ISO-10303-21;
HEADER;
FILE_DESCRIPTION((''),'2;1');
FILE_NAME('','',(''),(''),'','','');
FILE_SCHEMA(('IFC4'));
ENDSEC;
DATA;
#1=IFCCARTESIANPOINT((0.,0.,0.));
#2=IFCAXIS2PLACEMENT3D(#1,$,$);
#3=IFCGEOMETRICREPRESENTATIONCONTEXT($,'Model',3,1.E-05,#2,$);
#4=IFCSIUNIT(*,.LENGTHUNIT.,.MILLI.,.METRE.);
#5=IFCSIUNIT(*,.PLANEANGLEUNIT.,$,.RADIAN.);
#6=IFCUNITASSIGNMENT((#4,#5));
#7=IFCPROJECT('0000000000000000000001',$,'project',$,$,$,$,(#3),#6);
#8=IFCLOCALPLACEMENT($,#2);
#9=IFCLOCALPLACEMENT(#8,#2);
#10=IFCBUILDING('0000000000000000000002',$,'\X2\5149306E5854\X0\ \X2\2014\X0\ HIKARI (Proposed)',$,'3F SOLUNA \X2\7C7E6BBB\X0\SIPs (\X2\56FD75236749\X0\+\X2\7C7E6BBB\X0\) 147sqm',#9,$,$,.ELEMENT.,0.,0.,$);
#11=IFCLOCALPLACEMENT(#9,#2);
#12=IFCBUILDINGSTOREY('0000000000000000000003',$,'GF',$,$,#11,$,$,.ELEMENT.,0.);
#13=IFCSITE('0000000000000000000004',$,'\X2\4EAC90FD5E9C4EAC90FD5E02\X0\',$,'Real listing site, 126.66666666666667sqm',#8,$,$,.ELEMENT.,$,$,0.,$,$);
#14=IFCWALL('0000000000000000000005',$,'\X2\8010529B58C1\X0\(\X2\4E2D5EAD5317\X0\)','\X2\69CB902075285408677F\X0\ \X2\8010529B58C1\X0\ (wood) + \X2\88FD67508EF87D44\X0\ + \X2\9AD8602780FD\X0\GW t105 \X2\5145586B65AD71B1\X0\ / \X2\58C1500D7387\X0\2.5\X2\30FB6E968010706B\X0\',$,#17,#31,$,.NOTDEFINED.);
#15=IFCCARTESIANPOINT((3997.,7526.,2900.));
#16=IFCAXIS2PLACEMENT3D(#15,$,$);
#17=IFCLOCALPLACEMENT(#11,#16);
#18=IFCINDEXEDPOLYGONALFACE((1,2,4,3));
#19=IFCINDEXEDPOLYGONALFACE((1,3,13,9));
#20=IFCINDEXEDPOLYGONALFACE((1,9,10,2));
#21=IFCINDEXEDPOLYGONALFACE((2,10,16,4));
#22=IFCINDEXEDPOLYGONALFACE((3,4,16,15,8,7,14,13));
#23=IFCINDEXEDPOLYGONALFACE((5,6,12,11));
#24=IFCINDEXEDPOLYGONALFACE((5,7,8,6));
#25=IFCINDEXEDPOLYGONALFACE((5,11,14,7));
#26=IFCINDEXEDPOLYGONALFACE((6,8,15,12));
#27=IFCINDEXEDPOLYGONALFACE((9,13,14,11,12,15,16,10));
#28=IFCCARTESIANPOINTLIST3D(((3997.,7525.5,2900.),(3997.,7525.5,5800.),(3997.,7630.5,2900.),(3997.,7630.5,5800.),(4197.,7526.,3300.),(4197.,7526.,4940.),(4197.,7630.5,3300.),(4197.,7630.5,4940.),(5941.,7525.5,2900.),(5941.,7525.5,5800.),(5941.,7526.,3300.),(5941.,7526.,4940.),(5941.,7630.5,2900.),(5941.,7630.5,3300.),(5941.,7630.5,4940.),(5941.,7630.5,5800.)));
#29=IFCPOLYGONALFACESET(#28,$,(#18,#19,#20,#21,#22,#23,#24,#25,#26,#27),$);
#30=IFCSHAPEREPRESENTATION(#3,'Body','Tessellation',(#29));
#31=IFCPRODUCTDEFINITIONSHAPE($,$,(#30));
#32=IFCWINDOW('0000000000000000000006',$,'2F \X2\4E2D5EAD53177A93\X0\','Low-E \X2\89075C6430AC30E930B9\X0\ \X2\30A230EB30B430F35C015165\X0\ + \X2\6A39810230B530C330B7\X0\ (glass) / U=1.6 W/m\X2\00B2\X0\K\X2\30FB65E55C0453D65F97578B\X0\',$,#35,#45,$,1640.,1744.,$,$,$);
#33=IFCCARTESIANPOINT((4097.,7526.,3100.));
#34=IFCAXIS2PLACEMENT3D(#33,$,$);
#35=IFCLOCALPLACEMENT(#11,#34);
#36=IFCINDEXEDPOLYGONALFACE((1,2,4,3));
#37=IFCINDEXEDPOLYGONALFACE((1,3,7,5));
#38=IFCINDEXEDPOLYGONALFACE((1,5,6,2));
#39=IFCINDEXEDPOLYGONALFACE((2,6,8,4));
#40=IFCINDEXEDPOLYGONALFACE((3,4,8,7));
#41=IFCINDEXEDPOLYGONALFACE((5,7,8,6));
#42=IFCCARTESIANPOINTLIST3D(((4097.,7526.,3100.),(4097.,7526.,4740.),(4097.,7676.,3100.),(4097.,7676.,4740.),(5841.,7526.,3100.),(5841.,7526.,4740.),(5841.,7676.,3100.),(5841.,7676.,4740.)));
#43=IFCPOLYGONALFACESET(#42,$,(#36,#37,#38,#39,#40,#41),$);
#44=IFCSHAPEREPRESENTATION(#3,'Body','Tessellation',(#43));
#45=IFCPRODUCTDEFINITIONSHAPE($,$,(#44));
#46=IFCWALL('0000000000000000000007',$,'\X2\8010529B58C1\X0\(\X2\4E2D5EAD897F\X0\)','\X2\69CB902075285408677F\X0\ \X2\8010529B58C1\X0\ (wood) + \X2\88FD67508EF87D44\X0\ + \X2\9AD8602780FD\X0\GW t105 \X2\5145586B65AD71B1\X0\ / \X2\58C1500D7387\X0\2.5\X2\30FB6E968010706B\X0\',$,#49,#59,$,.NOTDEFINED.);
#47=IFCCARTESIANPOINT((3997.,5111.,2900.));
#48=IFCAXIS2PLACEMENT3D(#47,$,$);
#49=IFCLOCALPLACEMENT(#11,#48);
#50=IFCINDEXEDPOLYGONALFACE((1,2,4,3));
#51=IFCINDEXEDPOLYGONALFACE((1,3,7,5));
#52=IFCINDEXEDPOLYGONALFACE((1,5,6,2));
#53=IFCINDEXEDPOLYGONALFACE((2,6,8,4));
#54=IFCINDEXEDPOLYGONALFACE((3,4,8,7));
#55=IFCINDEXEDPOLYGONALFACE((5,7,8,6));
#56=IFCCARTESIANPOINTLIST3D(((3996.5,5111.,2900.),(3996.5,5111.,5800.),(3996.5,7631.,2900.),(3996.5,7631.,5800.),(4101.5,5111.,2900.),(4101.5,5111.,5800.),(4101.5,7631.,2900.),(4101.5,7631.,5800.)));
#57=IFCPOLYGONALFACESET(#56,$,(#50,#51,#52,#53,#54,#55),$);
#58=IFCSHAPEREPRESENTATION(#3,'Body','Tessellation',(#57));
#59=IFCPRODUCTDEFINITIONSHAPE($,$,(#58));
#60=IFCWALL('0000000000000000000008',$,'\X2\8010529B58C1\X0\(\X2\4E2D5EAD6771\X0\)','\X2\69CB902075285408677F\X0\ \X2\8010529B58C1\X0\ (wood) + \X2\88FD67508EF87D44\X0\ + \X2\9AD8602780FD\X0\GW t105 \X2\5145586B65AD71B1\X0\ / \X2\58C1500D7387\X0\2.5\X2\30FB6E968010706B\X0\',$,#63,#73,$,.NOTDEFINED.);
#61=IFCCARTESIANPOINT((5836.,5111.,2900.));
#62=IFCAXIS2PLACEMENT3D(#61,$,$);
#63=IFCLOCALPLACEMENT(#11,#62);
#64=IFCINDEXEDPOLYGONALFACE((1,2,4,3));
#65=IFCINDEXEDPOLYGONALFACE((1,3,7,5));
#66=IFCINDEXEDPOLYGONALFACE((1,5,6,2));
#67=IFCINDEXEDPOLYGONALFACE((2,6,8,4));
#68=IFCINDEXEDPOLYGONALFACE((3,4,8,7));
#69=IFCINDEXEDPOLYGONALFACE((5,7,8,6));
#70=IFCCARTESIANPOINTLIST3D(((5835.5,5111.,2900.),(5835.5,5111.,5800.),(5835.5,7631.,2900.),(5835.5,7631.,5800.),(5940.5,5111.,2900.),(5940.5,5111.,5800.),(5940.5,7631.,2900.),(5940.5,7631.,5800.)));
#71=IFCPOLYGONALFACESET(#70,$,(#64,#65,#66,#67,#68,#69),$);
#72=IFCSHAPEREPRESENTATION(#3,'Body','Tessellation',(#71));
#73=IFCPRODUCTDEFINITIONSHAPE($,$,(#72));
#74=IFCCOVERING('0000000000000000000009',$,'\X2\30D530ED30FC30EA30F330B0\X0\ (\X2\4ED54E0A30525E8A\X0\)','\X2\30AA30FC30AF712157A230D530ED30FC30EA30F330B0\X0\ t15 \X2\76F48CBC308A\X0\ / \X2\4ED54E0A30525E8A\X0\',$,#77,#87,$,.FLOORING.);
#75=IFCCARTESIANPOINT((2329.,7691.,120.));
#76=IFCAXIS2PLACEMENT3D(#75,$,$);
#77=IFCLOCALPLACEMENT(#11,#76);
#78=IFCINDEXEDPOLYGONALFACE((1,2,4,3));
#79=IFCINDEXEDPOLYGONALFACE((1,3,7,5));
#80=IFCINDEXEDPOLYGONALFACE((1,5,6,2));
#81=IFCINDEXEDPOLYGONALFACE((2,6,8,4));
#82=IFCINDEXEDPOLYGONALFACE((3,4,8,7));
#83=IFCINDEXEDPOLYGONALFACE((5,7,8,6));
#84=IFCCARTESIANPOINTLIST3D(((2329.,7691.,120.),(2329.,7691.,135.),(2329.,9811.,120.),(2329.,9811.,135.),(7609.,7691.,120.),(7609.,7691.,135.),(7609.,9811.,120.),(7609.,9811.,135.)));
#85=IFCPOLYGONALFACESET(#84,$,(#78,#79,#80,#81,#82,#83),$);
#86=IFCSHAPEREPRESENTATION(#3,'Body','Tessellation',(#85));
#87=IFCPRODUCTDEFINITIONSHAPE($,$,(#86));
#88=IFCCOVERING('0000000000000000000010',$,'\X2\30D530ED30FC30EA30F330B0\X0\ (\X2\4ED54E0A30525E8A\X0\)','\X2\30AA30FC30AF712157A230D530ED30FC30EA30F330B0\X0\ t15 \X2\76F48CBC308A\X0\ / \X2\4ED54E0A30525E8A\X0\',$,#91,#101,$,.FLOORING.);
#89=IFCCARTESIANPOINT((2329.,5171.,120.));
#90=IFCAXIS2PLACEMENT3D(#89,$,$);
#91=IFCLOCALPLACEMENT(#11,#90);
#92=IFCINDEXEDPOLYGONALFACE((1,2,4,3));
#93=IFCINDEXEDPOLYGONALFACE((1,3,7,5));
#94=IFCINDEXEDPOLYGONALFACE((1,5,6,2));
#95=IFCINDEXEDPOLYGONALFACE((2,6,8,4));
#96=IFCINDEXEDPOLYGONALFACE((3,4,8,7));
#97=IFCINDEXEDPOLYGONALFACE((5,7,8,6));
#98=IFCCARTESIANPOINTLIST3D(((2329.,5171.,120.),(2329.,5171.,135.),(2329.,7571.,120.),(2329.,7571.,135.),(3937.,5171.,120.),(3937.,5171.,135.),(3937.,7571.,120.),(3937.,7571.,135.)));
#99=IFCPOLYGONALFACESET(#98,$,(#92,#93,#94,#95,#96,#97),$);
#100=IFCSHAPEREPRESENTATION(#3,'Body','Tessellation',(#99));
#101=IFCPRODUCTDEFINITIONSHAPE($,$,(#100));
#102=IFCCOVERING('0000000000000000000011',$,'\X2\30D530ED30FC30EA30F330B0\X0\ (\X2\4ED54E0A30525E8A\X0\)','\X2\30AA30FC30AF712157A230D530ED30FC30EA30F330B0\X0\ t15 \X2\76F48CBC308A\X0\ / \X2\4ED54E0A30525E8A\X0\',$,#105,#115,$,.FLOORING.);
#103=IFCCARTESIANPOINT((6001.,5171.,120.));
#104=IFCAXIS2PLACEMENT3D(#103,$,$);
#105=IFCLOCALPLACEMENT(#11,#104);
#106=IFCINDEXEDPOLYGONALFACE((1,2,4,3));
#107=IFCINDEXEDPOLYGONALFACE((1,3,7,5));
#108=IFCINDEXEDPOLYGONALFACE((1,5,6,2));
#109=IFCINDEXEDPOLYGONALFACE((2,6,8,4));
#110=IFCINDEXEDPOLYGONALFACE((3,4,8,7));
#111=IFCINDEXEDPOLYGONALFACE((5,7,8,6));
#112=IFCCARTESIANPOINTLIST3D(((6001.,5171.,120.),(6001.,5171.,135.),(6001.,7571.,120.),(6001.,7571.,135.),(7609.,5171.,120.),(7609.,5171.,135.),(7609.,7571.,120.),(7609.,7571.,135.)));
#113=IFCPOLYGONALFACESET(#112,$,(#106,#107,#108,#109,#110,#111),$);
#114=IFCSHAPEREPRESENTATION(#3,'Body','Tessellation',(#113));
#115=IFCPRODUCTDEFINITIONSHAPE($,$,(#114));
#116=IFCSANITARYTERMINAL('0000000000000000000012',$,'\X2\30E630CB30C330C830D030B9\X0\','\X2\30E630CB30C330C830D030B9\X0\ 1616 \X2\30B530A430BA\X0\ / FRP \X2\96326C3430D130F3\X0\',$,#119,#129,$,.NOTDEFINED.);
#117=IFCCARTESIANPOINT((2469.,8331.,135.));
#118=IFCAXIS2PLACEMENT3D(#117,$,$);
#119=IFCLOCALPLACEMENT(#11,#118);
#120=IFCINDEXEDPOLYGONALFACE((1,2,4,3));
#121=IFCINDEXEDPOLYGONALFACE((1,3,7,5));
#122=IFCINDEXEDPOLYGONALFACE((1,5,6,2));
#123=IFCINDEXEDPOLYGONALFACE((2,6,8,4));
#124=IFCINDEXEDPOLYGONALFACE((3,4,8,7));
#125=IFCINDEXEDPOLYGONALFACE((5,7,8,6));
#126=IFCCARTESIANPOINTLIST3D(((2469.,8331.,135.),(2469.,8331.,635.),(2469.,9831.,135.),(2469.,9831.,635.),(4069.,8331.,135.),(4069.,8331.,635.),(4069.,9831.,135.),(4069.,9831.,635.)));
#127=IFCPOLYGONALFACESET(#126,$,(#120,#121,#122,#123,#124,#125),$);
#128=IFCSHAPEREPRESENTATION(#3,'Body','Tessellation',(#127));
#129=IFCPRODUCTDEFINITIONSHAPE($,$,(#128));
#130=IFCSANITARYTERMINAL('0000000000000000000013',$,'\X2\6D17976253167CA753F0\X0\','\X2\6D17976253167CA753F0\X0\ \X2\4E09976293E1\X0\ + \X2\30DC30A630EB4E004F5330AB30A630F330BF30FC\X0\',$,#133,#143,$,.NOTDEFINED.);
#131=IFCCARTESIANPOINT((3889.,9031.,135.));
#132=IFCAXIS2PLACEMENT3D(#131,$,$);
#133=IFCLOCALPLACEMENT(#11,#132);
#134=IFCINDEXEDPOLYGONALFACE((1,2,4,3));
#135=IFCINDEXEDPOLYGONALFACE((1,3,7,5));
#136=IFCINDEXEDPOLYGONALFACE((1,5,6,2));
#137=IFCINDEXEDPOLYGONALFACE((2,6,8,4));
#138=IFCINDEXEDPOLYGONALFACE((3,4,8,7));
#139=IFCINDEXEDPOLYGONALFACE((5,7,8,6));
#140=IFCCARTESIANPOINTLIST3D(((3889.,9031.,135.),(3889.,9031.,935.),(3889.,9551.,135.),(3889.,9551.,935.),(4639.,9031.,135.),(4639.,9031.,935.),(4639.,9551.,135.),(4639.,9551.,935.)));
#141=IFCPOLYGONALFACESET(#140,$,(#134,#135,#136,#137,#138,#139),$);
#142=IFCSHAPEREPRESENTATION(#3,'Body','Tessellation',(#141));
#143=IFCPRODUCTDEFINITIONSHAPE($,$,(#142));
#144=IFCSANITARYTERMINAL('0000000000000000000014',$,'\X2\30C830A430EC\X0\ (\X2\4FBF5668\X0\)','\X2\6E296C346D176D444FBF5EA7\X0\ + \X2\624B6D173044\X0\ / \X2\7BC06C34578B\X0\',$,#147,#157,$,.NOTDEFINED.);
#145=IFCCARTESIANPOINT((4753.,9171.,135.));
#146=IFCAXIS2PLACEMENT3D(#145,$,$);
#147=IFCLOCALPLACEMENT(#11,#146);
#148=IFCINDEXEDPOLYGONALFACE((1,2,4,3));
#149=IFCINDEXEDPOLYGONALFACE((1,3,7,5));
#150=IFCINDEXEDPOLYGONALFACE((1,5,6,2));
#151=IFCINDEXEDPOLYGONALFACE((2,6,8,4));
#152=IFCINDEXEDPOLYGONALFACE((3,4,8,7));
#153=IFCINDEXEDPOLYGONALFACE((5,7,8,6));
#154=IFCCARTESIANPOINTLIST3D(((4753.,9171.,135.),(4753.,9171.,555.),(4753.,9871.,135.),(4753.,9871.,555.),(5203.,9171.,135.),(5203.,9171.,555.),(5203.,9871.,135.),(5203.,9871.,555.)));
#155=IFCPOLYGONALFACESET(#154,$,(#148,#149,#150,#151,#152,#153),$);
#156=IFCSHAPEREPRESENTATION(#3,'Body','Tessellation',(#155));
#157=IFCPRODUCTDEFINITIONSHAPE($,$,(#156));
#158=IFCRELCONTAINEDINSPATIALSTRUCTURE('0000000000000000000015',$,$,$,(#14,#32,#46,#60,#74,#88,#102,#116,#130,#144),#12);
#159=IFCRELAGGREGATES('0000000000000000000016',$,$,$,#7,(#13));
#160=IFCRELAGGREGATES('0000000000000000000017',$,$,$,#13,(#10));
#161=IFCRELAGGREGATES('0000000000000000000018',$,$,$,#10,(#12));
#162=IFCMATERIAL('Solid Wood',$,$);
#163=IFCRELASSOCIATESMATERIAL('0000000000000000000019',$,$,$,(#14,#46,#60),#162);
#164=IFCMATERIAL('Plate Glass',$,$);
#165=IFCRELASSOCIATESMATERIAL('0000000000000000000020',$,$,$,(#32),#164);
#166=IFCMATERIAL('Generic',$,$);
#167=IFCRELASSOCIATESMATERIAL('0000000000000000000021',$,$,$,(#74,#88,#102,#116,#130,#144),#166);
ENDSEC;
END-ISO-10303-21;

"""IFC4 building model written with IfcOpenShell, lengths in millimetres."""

from ifc_helpers import new_model, si_unit, frame, frame_2d, origin, place, context, project, spatial, rectangle, extrude, material, element, fill, save


model = new_model("IFC4")

# Units and contexts
model_context = context("Model", 3, precision=1e-05, world=origin())
ifc_project = project(units=[si_unit("LENGTHUNIT", "METRE", prefix="MILLI"), si_unit("PLANEANGLEUNIT", "RADIAN")], contexts=[model_context])

# Site, building, storey
site_placement = place(None, origin())
site = spatial("IfcSite", under=ifc_project, at=site_placement, Name="京都府京都市", ObjectType="Real listing site, 126.66666666666667sqm", CompositionType="ELEMENT", RefElevation=0.0)
building_placement = place(site_placement, origin())
building = spatial("IfcBuilding", under=site, at=building_placement, Name="光の塔 — HIKARI (Proposed)", ObjectType="3F SOLUNA 籾殻SIPs (国産杉+籾殻) 147sqm", CompositionType="ELEMENT", ElevationOfRefHeight=0.0, ElevationOfTerrain=0.0)
storey_placement = place(building_placement, origin())
storey = spatial("IfcBuildingStorey", under=building, at=storey_placement, Name="GF", CompositionType="ELEMENT", Elevation=0.0)

# Shared definitions
ifc_material_1 = material(Name="Solid Wood")

# Shared definitions
ifc_material_2 = material(Name="Plate Glass")

# Wall, opening, window
wall_1_placement = place(storey_placement, frame((3997.0, 7526.0, 2900.0)))
wall_1 = element("IfcWall", 1, at=wall_1_placement, inside=storey, material=ifc_material_1, Name="耐力壁(中庭北)", Description="構造用合板 耐力壁 (wood) + 製材軸組 + 高性能GW t105 充填断熱 / 壁倍率2.5・準耐火", PredefinedType="NOTDEFINED", context=model_context, shape_type="SweptSolid", body=[
    extrude(rectangle(XDim=1944.0, YDim=105.0, at=frame_2d((972.0, 52.0))), frame((3997.0, 7526.0, 2900.0)), (0.0, 0.0, 1.0), 2900.0),
])
opening_1_placement = place(storey_placement, frame((4097.0, 7526.0, 3100.0)))
opening_1 = element("IfcOpeningElement", 2, at=opening_1_placement, cuts=wall_1, PredefinedType="NOTDEFINED", context=model_context, shape_type="SweptSolid", body=[
    extrude(rectangle(XDim=1744.0, YDim=150.0, at=frame_2d((872.0, 75.0))), frame((4097.0, 7526.0, 3100.0)), (0.0, 0.0, 1.0), 1640.0),
])
window_1_placement = place(storey_placement, frame((4097.0, 7526.0, 3100.0)))
window_1 = element("IfcWindow", 3, at=window_1_placement, inside=storey, material=ifc_material_2, Name="2F 中庭北窓", Description="Low-E 複層ガラス アルゴン封入 + 樹脂サッシ (glass) / U=1.6 W/m²K・日射取得型", OverallHeight=1640.0, OverallWidth=1744.0, context=model_context, shape_type="SweptSolid", body=[
    extrude(rectangle(XDim=1744.0, YDim=150.0, at=frame_2d((872.0, 75.0))), frame((4097.0, 7526.0, 3100.0)), (0.0, 0.0, 1.0), 1640.0),
])
fill(opening_1, window_1)

# Walls
wall_2_placement = place(storey_placement, frame((3997.0, 5111.0, 2900.0)))
element("IfcWall", 4, at=wall_2_placement, inside=storey, material=ifc_material_1, Name="耐力壁(中庭西)", Description="構造用合板 耐力壁 (wood) + 製材軸組 + 高性能GW t105 充填断熱 / 壁倍率2.5・準耐火", PredefinedType="NOTDEFINED", context=model_context, shape_type="SweptSolid", body=[
    extrude(rectangle(XDim=105.0, YDim=2520.0, at=frame_2d((52.0, 1260.0))), frame((3997.0, 5111.0, 2900.0)), (0.0, 0.0, 1.0), 2900.0),
])
wall_3_placement = place(storey_placement, frame((5836.0, 5111.0, 2900.0)))
element("IfcWall", 5, at=wall_3_placement, inside=storey, material=ifc_material_1, Name="耐力壁(中庭東)", Description="構造用合板 耐力壁 (wood) + 製材軸組 + 高性能GW t105 充填断熱 / 壁倍率2.5・準耐火", PredefinedType="NOTDEFINED", context=model_context, shape_type="SweptSolid", body=[
    extrude(rectangle(XDim=105.0, YDim=2520.0, at=frame_2d((52.0, 1260.0))), frame((5836.0, 5111.0, 2900.0)), (0.0, 0.0, 1.0), 2900.0),
])

# Coverings
ifc_material_3 = material(Name="Generic")
covering_1_placement = place(storey_placement, frame((2329.0, 7691.0, 120.0)))
element("IfcCovering", 6, at=covering_1_placement, inside=storey, material=ifc_material_3, Name="フローリング (仕上げ床)", Description="オーク無垢フローリング t15 直貼り / 仕上げ床", PredefinedType="FLOORING", context=model_context, shape_type="SweptSolid", body=[
    extrude(rectangle(XDim=5280.0, YDim=2120.0, at=frame_2d((2640.0, 1060.0))), frame((2329.0, 7691.0, 120.0)), (0.0, 0.0, 1.0), 15.0),
])
covering_2_placement = place(storey_placement, frame((2329.0, 5171.0, 120.0)))
element("IfcCovering", 7, at=covering_2_placement, inside=storey, material=ifc_material_3, Name="フローリング (仕上げ床)", Description="オーク無垢フローリング t15 直貼り / 仕上げ床", PredefinedType="FLOORING", context=model_context, shape_type="SweptSolid", body=[
    extrude(rectangle(XDim=1608.0, YDim=2400.0, at=frame_2d((804.0, 1200.0))), frame((2329.0, 5171.0, 120.0)), (0.0, 0.0, 1.0), 15.0),
])
covering_3_placement = place(storey_placement, frame((6001.0, 5171.0, 120.0)))
element("IfcCovering", 8, at=covering_3_placement, inside=storey, material=ifc_material_3, Name="フローリング (仕上げ床)", Description="オーク無垢フローリング t15 直貼り / 仕上げ床", PredefinedType="FLOORING", context=model_context, shape_type="SweptSolid", body=[
    extrude(rectangle(XDim=1608.0, YDim=2400.0, at=frame_2d((804.0, 1200.0))), frame((6001.0, 5171.0, 120.0)), (0.0, 0.0, 1.0), 15.0),
])

# Sanitary terminals
sanitary_terminal_1_placement = place(storey_placement, frame((2469.0, 8331.0, 135.0)))
element("IfcSanitaryTerminal", 9, at=sanitary_terminal_1_placement, inside=storey, material=ifc_material_3, Name="ユニットバス", Description="ユニットバス 1616 サイズ / FRP 防水パン", PredefinedType="NOTDEFINED", context=model_context, shape_type="SweptSolid", body=[
    extrude(rectangle(XDim=1600.0, YDim=1500.0, at=frame_2d((800.0, 750.0))), frame((2469.0, 8331.0, 135.0)), (0.0, 0.0, 1.0), 500.0),
])
sanitary_terminal_2_placement = place(storey_placement, frame((3889.0, 9031.0, 135.0)))
element("IfcSanitaryTerminal", 10, at=sanitary_terminal_2_placement, inside=storey, material=ifc_material_3, Name="洗面化粧台", Description="洗面化粧台 三面鏡 + ボウル一体カウンター", PredefinedType="NOTDEFINED", context=model_context, shape_type="SweptSolid", body=[
    extrude(rectangle(XDim=750.0, YDim=520.0, at=frame_2d((375.0, 260.0))), frame((3889.0, 9031.0, 135.0)), (0.0, 0.0, 1.0), 800.0),
])
sanitary_terminal_3_placement = place(storey_placement, frame((4753.0, 9171.0, 135.0)))
element("IfcSanitaryTerminal", 11, at=sanitary_terminal_3_placement, inside=storey, material=ifc_material_3, Name="トイレ (便器)", Description="温水洗浄便座 + 手洗い / 節水型", PredefinedType="NOTDEFINED", context=model_context, shape_type="SweptSolid", body=[
    extrude(rectangle(XDim=450.0, YDim=700.0, at=frame_2d((225.0, 350.0))), frame((4753.0, 9171.0, 135.0)), (0.0, 0.0, 1.0), 420.0),
])

save(model, "model.ifc")
